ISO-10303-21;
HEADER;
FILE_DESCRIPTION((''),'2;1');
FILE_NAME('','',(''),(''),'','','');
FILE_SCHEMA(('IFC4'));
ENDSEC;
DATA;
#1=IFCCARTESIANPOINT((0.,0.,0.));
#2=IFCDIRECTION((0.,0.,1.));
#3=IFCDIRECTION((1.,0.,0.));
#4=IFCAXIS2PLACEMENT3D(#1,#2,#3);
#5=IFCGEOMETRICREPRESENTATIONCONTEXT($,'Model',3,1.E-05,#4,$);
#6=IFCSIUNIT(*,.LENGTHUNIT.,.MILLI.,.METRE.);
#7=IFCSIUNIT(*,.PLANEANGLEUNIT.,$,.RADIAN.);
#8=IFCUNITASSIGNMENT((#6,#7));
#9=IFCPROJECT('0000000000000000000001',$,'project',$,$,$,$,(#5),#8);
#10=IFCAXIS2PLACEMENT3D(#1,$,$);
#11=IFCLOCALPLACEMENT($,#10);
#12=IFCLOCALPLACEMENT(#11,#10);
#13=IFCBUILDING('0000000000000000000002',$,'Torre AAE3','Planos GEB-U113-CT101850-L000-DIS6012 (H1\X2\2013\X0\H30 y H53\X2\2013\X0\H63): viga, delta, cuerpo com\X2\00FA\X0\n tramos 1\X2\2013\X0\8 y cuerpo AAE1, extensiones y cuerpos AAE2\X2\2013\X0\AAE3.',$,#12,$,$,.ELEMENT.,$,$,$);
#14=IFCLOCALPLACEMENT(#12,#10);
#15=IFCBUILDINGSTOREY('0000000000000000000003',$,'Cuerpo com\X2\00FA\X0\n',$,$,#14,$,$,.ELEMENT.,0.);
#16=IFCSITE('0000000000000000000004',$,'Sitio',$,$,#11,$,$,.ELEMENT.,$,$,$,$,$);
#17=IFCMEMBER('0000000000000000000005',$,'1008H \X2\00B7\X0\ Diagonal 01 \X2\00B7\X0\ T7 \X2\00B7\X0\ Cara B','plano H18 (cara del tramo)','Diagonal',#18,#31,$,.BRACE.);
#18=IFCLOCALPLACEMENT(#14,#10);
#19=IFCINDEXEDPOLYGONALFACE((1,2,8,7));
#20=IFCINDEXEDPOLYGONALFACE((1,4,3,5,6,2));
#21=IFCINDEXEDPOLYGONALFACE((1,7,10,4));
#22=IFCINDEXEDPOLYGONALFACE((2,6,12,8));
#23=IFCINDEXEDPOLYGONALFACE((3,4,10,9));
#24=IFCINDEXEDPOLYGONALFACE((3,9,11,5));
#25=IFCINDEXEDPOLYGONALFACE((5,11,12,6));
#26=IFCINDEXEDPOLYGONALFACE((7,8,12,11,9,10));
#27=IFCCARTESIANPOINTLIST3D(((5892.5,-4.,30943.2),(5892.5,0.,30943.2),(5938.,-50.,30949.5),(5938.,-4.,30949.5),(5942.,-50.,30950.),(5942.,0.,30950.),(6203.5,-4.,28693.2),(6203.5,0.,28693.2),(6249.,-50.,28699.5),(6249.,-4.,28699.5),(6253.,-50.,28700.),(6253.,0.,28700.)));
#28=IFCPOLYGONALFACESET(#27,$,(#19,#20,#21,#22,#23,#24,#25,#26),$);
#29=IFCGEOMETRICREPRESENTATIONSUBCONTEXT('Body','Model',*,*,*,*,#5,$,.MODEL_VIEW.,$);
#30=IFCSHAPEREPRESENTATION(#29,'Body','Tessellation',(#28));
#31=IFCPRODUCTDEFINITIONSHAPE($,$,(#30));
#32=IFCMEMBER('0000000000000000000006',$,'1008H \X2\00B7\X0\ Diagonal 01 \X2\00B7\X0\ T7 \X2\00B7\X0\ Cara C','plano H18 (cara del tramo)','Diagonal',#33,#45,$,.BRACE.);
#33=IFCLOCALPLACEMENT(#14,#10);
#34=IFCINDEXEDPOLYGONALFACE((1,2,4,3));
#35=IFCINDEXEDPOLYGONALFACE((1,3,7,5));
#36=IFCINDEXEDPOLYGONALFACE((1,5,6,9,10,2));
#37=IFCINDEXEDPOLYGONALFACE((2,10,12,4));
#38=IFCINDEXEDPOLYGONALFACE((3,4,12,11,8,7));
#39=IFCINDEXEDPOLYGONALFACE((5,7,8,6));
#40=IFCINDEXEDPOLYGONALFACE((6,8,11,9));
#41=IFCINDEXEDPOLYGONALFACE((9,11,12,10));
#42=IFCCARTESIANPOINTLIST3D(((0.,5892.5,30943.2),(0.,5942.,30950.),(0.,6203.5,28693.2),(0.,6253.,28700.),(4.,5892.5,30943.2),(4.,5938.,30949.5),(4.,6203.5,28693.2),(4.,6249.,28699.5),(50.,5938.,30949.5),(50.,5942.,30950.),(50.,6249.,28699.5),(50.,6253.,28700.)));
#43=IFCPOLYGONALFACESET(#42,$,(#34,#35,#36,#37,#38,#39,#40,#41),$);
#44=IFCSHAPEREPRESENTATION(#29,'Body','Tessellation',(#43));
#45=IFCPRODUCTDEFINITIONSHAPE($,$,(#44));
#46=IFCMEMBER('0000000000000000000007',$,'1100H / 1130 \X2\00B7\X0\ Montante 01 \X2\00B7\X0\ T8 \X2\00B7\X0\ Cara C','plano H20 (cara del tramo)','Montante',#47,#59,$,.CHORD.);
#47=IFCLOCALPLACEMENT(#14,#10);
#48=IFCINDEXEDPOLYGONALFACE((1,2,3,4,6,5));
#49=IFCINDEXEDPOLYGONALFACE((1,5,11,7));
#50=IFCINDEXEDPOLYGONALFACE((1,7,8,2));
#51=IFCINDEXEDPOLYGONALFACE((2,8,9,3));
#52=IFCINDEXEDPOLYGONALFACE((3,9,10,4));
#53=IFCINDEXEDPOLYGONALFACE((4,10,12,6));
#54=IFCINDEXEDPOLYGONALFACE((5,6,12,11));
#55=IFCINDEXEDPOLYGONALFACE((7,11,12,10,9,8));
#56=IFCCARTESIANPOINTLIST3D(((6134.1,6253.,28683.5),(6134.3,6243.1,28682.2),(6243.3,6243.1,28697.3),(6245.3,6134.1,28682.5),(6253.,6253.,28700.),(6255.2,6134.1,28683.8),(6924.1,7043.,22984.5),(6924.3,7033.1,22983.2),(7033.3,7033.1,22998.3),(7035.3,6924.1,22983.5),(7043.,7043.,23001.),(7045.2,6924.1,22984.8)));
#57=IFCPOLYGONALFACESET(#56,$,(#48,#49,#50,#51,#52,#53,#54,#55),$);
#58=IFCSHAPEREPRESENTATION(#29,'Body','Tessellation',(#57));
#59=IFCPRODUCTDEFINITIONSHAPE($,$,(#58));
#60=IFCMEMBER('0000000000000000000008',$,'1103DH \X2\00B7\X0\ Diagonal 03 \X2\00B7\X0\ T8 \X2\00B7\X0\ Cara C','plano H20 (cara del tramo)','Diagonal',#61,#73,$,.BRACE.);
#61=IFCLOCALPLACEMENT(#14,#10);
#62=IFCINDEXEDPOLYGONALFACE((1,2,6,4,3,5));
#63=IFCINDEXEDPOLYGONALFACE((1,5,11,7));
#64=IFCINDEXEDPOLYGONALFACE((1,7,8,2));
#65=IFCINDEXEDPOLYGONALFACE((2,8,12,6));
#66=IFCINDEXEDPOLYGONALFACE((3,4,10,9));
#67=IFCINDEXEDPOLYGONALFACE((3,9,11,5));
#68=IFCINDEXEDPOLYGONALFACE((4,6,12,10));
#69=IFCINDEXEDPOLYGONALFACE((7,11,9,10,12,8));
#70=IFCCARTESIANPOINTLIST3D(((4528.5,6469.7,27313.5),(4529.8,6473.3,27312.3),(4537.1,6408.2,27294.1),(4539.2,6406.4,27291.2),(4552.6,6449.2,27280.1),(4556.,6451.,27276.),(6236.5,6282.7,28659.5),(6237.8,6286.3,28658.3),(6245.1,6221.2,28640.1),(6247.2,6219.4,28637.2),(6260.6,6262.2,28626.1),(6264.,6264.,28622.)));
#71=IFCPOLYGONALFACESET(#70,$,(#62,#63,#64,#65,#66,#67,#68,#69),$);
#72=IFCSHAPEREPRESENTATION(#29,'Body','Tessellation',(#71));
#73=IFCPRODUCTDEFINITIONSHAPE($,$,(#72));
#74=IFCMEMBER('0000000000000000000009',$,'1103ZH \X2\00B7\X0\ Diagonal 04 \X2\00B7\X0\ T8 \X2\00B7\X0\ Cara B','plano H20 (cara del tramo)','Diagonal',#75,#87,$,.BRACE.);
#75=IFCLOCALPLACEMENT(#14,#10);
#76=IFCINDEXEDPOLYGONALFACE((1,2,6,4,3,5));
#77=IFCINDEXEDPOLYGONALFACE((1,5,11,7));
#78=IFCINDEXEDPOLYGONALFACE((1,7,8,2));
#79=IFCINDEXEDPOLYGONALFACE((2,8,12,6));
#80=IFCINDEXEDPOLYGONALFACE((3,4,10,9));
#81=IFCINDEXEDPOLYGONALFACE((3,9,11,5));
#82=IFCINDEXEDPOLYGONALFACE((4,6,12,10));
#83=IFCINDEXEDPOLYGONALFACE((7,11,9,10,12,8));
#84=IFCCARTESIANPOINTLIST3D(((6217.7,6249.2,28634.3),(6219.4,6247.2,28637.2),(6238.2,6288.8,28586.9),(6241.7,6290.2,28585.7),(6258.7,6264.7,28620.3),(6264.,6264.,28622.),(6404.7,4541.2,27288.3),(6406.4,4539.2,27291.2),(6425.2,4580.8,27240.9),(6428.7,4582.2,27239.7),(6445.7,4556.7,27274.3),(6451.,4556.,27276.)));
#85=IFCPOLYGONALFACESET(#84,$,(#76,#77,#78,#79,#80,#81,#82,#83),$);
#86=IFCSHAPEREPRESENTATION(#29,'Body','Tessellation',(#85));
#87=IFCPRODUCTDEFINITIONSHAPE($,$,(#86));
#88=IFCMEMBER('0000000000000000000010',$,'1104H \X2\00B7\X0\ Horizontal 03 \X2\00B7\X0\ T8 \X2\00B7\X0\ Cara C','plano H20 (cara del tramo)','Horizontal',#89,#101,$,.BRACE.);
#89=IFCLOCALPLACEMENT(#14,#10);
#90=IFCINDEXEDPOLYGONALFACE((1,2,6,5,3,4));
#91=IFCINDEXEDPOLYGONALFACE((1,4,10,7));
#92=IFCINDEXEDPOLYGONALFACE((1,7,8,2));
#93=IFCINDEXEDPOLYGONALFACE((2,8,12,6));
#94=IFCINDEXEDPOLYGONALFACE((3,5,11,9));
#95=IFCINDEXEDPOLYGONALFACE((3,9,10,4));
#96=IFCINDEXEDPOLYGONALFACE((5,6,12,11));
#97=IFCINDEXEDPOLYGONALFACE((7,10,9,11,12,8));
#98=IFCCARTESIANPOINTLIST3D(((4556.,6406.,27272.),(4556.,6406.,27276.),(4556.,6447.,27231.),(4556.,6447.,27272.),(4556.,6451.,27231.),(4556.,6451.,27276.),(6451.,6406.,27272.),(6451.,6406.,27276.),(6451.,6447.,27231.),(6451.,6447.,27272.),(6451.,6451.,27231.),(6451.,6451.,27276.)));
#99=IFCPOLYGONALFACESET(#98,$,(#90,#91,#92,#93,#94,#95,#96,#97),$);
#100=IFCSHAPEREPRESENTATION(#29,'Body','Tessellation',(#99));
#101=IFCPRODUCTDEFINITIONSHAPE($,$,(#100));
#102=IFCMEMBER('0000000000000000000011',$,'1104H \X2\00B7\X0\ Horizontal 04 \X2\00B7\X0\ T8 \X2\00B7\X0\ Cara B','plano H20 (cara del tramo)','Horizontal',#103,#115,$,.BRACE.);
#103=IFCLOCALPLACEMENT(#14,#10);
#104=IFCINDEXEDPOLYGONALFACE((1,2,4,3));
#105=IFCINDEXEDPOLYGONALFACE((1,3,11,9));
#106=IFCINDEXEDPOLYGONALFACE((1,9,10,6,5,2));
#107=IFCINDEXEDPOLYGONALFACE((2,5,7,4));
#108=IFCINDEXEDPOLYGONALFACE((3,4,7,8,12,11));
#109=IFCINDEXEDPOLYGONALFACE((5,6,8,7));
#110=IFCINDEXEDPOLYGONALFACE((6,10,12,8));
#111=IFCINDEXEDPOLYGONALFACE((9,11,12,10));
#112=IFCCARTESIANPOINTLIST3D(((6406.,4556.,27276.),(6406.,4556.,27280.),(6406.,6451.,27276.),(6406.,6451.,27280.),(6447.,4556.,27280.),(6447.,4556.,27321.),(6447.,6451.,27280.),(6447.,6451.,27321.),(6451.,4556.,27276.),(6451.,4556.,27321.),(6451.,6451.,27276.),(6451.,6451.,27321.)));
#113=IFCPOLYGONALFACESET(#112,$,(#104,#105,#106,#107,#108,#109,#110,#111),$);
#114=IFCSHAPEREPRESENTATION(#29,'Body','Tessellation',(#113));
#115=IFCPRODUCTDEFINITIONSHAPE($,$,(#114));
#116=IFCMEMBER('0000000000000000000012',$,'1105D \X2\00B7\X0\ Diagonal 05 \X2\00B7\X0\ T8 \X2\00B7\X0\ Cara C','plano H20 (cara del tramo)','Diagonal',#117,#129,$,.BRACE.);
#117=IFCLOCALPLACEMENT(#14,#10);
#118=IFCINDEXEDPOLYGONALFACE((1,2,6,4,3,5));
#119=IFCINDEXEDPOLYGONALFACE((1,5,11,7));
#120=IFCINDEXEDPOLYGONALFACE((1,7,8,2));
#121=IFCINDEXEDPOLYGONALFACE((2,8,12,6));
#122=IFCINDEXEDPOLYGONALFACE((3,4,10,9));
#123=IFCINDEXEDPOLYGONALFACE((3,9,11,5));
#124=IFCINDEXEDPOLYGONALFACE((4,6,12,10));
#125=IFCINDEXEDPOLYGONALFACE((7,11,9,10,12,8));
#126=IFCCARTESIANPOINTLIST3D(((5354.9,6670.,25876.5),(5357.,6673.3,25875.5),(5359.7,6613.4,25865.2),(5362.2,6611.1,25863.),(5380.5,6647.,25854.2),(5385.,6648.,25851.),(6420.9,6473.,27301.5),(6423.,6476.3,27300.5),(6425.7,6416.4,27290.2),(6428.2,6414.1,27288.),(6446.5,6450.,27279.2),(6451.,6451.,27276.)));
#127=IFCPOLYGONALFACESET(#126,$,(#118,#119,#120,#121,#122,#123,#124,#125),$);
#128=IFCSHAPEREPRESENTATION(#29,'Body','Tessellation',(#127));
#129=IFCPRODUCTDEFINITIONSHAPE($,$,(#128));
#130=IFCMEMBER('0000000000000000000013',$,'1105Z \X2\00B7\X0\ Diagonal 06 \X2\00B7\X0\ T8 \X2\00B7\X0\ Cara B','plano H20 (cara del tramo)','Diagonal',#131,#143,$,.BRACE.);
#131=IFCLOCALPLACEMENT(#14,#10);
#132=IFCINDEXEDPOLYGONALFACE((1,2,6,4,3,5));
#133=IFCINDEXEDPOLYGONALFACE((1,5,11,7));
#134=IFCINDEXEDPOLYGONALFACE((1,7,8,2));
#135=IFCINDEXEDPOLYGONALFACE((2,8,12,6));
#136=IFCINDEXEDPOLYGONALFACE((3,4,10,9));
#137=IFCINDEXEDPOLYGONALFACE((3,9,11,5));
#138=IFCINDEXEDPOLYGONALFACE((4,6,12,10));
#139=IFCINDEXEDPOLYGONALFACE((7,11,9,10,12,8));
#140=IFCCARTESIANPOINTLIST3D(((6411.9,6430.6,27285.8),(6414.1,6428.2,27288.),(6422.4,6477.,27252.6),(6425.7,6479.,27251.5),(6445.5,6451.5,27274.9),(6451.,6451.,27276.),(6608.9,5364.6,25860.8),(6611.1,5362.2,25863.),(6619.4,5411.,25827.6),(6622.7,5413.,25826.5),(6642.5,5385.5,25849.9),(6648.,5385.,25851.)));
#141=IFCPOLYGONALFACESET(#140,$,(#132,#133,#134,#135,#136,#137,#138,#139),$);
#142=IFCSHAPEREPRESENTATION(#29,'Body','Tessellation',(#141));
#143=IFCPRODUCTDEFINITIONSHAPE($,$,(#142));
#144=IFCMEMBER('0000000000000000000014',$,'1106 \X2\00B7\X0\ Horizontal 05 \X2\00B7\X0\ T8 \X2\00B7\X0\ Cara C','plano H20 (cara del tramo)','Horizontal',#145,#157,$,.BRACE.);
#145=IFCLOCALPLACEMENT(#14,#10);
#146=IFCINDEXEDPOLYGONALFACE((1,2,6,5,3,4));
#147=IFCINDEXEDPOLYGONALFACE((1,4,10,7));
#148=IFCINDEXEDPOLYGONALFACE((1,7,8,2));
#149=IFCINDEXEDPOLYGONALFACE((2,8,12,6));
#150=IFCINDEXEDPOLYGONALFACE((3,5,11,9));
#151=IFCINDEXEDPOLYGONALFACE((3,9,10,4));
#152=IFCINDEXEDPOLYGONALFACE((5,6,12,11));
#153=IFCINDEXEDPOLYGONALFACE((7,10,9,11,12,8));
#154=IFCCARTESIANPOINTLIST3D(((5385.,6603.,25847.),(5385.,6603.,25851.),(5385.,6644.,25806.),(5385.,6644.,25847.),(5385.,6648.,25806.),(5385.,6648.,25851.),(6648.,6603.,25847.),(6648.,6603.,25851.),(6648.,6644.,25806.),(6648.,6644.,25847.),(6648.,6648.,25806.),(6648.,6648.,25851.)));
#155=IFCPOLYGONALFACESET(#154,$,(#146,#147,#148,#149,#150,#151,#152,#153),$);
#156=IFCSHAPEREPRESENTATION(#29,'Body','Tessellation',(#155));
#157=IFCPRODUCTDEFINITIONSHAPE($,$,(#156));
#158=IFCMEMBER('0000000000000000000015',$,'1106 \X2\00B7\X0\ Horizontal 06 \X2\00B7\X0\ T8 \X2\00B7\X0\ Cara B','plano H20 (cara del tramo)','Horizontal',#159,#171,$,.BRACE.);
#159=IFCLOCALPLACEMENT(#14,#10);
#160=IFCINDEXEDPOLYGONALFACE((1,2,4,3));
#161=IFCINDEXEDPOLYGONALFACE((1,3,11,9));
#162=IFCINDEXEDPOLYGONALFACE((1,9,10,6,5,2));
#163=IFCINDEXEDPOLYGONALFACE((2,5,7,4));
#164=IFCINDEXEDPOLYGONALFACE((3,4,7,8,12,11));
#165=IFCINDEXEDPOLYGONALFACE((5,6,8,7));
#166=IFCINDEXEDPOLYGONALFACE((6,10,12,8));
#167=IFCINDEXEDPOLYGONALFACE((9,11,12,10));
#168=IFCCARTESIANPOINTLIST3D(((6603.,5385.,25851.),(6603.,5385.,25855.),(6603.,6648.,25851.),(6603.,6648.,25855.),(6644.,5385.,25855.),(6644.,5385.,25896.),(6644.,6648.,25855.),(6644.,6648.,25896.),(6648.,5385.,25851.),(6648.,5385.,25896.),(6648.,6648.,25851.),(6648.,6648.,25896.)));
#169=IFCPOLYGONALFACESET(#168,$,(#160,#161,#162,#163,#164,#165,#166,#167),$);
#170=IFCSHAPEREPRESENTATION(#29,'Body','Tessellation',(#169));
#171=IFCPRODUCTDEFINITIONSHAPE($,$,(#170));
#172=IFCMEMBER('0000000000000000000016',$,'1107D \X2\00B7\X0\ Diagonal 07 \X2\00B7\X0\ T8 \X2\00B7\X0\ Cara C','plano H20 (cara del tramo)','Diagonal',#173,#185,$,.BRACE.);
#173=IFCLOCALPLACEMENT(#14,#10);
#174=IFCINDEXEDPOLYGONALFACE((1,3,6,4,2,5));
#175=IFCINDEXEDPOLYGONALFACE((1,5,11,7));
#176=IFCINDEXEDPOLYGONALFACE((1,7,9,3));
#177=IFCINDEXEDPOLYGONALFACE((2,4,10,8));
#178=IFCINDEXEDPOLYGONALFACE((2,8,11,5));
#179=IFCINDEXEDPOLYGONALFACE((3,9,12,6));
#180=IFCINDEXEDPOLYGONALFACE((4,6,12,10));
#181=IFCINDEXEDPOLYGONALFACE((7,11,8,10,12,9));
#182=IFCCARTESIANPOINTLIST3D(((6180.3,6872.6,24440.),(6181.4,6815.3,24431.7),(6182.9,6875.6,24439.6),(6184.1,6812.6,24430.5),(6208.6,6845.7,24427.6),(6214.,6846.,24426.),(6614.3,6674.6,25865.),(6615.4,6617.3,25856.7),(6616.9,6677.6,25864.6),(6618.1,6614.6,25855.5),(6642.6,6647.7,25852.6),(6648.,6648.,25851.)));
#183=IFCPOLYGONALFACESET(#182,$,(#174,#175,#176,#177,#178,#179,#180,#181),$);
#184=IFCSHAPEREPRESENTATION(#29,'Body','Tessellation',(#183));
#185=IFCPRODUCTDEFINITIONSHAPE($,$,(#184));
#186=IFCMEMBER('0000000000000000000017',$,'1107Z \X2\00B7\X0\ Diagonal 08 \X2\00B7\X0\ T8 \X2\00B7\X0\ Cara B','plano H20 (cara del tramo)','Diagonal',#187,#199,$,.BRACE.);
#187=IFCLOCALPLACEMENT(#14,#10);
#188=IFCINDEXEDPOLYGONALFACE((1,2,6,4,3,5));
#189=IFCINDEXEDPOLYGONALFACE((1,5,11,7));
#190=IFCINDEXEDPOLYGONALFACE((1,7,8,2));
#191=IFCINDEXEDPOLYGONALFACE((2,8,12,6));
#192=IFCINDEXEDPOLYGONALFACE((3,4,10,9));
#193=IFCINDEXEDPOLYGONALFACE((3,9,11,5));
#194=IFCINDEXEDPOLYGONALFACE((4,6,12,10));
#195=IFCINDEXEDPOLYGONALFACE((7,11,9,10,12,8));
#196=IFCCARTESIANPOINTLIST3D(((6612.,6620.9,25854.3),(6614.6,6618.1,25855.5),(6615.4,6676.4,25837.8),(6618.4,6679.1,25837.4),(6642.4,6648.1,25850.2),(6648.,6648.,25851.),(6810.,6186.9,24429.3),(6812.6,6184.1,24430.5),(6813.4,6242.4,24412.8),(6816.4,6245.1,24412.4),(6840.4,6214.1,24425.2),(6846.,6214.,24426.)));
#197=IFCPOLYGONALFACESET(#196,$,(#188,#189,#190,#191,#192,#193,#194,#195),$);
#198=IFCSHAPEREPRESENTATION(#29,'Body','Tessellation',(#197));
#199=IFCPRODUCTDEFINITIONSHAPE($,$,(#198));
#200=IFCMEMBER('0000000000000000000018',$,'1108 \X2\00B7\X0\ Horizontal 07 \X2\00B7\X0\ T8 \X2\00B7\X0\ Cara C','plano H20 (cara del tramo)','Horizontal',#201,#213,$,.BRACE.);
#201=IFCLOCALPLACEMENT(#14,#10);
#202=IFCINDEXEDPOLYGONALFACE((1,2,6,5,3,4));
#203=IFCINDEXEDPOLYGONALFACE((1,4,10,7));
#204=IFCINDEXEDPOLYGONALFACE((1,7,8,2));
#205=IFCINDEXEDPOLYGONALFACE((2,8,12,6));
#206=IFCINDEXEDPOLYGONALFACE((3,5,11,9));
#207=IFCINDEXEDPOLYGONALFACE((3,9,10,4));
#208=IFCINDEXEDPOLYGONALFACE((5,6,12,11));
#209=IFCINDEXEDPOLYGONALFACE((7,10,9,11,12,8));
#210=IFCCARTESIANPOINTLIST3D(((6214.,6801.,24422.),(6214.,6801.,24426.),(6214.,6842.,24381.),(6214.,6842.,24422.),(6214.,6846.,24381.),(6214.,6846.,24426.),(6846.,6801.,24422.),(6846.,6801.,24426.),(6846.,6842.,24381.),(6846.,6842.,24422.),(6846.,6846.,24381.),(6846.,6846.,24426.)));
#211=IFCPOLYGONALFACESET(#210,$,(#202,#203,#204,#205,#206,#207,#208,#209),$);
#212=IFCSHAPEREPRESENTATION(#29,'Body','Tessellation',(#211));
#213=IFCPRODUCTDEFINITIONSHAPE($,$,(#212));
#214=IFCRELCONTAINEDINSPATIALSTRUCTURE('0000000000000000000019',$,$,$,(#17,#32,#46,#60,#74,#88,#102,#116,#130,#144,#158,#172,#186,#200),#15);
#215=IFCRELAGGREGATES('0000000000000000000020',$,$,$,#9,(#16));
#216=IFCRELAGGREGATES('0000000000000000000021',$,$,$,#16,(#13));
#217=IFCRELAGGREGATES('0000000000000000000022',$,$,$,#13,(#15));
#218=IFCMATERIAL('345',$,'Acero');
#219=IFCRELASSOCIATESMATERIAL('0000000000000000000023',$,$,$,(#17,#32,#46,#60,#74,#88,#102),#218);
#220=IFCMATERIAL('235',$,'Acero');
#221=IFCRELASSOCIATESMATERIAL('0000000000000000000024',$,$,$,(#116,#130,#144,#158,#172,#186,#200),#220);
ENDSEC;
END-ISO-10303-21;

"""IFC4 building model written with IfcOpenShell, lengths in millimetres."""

from ifc_helpers import new_model, si_unit, frame, frame_2d, origin, origin_with_axes, place, context, subcontext, project, spatial, l_section, extrude, material, element, save


model = new_model("IFC4")

# Units and contexts
model_context = context("Model", 3, precision=1e-05, world=origin_with_axes())
body_context = subcontext(model_context, "Body", "Model", "MODEL_VIEW")
ifc_project = project(units=[si_unit("LENGTHUNIT", "METRE", prefix="MILLI"), si_unit("PLANEANGLEUNIT", "RADIAN")], contexts=[model_context])

# Site, building, storey
site_placement = place(None, origin())
site = spatial("IfcSite", under=ifc_project, at=site_placement, Name="Sitio", CompositionType="ELEMENT")
building_placement = place(site_placement, origin())
building = spatial("IfcBuilding", under=site, at=building_placement, Name="Torre AAE3", Description="Planos GEB-U113-CT101850-L000-DIS6012 (H1–H30 y H53–H63): viga, delta, cuerpo común tramos 1–8 y cuerpo AAE1, extensiones y cuerpos AAE2–AAE3.", CompositionType="ELEMENT")
storey_placement = place(building_placement, origin())
storey = spatial("IfcBuildingStorey", under=building, at=storey_placement, Name="Cuerpo común", CompositionType="ELEMENT", Elevation=0.0)

# Members
ifc_material_1 = material(Name="345", Category="Acero")
for number, where, z_axis, x_axis, name in (
    (1, (6253.0, 0.0, 28700.0), (-0.13692, 0.0, 0.990582), (-0.990582, 0.0, -0.13692), "1008H · Diagonal 01 · T7 · Cara B"),
    (2, (0.0, 6253.0, 28700.0), (0.0, -0.13692, 0.990582), (0.0, -0.990582, -0.13692), "1008H · Diagonal 01 · T7 · Cara C"),
):
    element("IfcMember", number, at=place(storey_placement, frame(where, z_axis=z_axis, x_axis=x_axis)), inside=storey, material=ifc_material_1, Name=name, Description="plano H18 (cara del tramo)", ObjectType="Diagonal", PredefinedType="BRACE", context=body_context, shape_type="SweptSolid", body=[
        extrude(l_section(Depth=50.0, Width=50.0, Thickness=4.0, at=frame_2d((25.0, 25.0))), None, (0.0, 0.0, 1.0), 2271.4),
    ])
member_1_placement = place(storey_placement, frame((6253.0, 6253.0, 28700.0), z_axis=(0.136032, 0.136032, -0.981321), x_axis=(0.018678, -0.990705, -0.134743)))
element("IfcMember", 3, at=member_1_placement, inside=storey, material=ifc_material_1, Name="1100H / 1130 · Montante 01 · T8 · Cara C", Description="plano H20 (cara del tramo)", ObjectType="Montante", PredefinedType="CHORD", context=body_context, shape_type="SweptSolid", body=[
    extrude(l_section(Depth=120.0, Width=120.0, Thickness=10.0, at=frame_2d((60.0, 60.0))), None, (0.0, 0.0, 1.0), 5807.5),
])
for number, where, z_axis, x_axis, name in (
    (4, (6264.0, 6264.0, 28622.0), (-0.782536, 0.085676, -0.616682), (-0.336961, -0.891166, 0.303776), "1103DH · Diagonal 03 · T8 · Cara C"),
    (5, (6264.0, 6264.0, 28622.0), (0.085676, -0.782536, -0.616682), (-0.891166, -0.336961, 0.303776), "1103ZH · Diagonal 04 · T8 · Cara B"),
):
    element("IfcMember", number, at=place(storey_placement, frame(where, z_axis=z_axis, x_axis=x_axis)), inside=storey, material=ifc_material_1, Name=name, Description="plano H20 (cara del tramo)", ObjectType="Diagonal", PredefinedType="BRACE", context=body_context, shape_type="SweptSolid", body=[
        extrude(l_section(Depth=50.0, Width=50.0, Thickness=4.0, at=frame_2d((25.0, 25.0))), None, (0.0, 0.0, 1.0), 2182.6),
    ])
for number, where, z_axis, x_axis, name in (
    (6, (4556.0, 6451.0, 27276.0), (1.0, 0.0, 0.0), (0.0, -1.0, 0.0), "1104H · Horizontal 03 · T8 · Cara C"),
    (7, (6451.0, 4556.0, 27276.0), (0.0, 1.0, 0.0), (-1.0, 0.0, 0.0), "1104H · Horizontal 04 · T8 · Cara B"),
):
    element("IfcMember", number, at=place(storey_placement, frame(where, z_axis=z_axis, x_axis=x_axis)), inside=storey, material=ifc_material_1, Name=name, Description="plano H20 (cara del tramo)", ObjectType="Horizontal", PredefinedType="BRACE", context=body_context, shape_type="SweptSolid", body=[
        extrude(l_section(Depth=45.0, Width=45.0, Thickness=4.0, at=frame_2d((22.5, 22.5))), None, (0.0, 0.0, 1.0), 1895.0),
    ])
ifc_material_2 = material(Name="235", Category="Acero")
for number, where, z_axis, x_axis, name in (
    (8, (6451.0, 6451.0, 27276.0), (-0.595374, 0.110027, -0.79588), (-0.507658, -0.819305, 0.266499), "1105D · Diagonal 05 · T8 · Cara C"),
    (9, (6451.0, 6451.0, 27276.0), (0.110027, -0.595374, -0.79588), (-0.819305, -0.507658, 0.266499), "1105Z · Diagonal 06 · T8 · Cara B"),
):
    element("IfcMember", number, at=place(storey_placement, frame(where, z_axis=z_axis, x_axis=x_axis)), inside=storey, material=ifc_material_2, Name=name, Description="plano H20 (cara del tramo)", ObjectType="Diagonal", PredefinedType="BRACE", context=body_context, shape_type="SweptSolid", body=[
        extrude(l_section(Depth=45.0, Width=45.0, Thickness=4.0, at=frame_2d((22.5, 22.5))), None, (0.0, 0.0, 1.0), 1790.5),
    ])
for number, where, z_axis, x_axis, name in (
    (10, (5385.0, 6648.0, 25851.0), (1.0, 0.0, 0.0), (0.0, -1.0, 0.0), "1106 · Horizontal 05 · T8 · Cara C"),
    (11, (6648.0, 5385.0, 25851.0), (0.0, 1.0, 0.0), (-1.0, 0.0, 0.0), "1106 · Horizontal 06 · T8 · Cara B"),
):
    element("IfcMember", number, at=place(storey_placement, frame(where, z_axis=z_axis, x_axis=x_axis)), inside=storey, material=ifc_material_2, Name=name, Description="plano H20 (cara del tramo)", ObjectType="Horizontal", PredefinedType="BRACE", context=body_context, shape_type="SweptSolid", body=[
        extrude(l_section(Depth=45.0, Width=45.0, Thickness=4.0, at=frame_2d((22.5, 22.5))), None, (0.0, 0.0, 1.0), 1263.0),
    ])
for number, where, z_axis, x_axis, name in (
    (12, (6648.0, 6648.0, 25851.0), (-0.288808, 0.131761, -0.948277), (-0.663539, -0.741556, 0.099051), "1107D · Diagonal 07 · T8 · Cara C"),
    (13, (6648.0, 6648.0, 25851.0), (0.131761, -0.288808, -0.948277), (-0.741556, -0.663539, 0.099051), "1107Z · Diagonal 08 · T8 · Cara B"),
):
    element("IfcMember", number, at=place(storey_placement, frame(where, z_axis=z_axis, x_axis=x_axis)), inside=storey, material=ifc_material_2, Name=name, Description="plano H20 (cara del tramo)", ObjectType="Diagonal", PredefinedType="BRACE", context=body_context, shape_type="SweptSolid", body=[
        extrude(l_section(Depth=45.0, Width=45.0, Thickness=4.0, at=frame_2d((22.5, 22.5))), None, (0.0, 0.0, 1.0), 1502.7),
    ])
for number, where, z_axis, x_axis, name in (
    (14, (6214.0, 6846.0, 24426.0), (1.0, 0.0, 0.0), (0.0, -1.0, 0.0), "1108 · Horizontal 07 · T8 · Cara C"),
):
    element("IfcMember", number, at=place(storey_placement, frame(where, z_axis=z_axis, x_axis=x_axis)), inside=storey, material=ifc_material_2, Name=name, Description="plano H20 (cara del tramo)", ObjectType="Horizontal", PredefinedType="BRACE", context=body_context, shape_type="SweptSolid", body=[
        extrude(l_section(Depth=45.0, Width=45.0, Thickness=4.0, at=frame_2d((22.5, 22.5))), None, (0.0, 0.0, 1.0), 632.0),
    ])

save(model, "model.ifc")
